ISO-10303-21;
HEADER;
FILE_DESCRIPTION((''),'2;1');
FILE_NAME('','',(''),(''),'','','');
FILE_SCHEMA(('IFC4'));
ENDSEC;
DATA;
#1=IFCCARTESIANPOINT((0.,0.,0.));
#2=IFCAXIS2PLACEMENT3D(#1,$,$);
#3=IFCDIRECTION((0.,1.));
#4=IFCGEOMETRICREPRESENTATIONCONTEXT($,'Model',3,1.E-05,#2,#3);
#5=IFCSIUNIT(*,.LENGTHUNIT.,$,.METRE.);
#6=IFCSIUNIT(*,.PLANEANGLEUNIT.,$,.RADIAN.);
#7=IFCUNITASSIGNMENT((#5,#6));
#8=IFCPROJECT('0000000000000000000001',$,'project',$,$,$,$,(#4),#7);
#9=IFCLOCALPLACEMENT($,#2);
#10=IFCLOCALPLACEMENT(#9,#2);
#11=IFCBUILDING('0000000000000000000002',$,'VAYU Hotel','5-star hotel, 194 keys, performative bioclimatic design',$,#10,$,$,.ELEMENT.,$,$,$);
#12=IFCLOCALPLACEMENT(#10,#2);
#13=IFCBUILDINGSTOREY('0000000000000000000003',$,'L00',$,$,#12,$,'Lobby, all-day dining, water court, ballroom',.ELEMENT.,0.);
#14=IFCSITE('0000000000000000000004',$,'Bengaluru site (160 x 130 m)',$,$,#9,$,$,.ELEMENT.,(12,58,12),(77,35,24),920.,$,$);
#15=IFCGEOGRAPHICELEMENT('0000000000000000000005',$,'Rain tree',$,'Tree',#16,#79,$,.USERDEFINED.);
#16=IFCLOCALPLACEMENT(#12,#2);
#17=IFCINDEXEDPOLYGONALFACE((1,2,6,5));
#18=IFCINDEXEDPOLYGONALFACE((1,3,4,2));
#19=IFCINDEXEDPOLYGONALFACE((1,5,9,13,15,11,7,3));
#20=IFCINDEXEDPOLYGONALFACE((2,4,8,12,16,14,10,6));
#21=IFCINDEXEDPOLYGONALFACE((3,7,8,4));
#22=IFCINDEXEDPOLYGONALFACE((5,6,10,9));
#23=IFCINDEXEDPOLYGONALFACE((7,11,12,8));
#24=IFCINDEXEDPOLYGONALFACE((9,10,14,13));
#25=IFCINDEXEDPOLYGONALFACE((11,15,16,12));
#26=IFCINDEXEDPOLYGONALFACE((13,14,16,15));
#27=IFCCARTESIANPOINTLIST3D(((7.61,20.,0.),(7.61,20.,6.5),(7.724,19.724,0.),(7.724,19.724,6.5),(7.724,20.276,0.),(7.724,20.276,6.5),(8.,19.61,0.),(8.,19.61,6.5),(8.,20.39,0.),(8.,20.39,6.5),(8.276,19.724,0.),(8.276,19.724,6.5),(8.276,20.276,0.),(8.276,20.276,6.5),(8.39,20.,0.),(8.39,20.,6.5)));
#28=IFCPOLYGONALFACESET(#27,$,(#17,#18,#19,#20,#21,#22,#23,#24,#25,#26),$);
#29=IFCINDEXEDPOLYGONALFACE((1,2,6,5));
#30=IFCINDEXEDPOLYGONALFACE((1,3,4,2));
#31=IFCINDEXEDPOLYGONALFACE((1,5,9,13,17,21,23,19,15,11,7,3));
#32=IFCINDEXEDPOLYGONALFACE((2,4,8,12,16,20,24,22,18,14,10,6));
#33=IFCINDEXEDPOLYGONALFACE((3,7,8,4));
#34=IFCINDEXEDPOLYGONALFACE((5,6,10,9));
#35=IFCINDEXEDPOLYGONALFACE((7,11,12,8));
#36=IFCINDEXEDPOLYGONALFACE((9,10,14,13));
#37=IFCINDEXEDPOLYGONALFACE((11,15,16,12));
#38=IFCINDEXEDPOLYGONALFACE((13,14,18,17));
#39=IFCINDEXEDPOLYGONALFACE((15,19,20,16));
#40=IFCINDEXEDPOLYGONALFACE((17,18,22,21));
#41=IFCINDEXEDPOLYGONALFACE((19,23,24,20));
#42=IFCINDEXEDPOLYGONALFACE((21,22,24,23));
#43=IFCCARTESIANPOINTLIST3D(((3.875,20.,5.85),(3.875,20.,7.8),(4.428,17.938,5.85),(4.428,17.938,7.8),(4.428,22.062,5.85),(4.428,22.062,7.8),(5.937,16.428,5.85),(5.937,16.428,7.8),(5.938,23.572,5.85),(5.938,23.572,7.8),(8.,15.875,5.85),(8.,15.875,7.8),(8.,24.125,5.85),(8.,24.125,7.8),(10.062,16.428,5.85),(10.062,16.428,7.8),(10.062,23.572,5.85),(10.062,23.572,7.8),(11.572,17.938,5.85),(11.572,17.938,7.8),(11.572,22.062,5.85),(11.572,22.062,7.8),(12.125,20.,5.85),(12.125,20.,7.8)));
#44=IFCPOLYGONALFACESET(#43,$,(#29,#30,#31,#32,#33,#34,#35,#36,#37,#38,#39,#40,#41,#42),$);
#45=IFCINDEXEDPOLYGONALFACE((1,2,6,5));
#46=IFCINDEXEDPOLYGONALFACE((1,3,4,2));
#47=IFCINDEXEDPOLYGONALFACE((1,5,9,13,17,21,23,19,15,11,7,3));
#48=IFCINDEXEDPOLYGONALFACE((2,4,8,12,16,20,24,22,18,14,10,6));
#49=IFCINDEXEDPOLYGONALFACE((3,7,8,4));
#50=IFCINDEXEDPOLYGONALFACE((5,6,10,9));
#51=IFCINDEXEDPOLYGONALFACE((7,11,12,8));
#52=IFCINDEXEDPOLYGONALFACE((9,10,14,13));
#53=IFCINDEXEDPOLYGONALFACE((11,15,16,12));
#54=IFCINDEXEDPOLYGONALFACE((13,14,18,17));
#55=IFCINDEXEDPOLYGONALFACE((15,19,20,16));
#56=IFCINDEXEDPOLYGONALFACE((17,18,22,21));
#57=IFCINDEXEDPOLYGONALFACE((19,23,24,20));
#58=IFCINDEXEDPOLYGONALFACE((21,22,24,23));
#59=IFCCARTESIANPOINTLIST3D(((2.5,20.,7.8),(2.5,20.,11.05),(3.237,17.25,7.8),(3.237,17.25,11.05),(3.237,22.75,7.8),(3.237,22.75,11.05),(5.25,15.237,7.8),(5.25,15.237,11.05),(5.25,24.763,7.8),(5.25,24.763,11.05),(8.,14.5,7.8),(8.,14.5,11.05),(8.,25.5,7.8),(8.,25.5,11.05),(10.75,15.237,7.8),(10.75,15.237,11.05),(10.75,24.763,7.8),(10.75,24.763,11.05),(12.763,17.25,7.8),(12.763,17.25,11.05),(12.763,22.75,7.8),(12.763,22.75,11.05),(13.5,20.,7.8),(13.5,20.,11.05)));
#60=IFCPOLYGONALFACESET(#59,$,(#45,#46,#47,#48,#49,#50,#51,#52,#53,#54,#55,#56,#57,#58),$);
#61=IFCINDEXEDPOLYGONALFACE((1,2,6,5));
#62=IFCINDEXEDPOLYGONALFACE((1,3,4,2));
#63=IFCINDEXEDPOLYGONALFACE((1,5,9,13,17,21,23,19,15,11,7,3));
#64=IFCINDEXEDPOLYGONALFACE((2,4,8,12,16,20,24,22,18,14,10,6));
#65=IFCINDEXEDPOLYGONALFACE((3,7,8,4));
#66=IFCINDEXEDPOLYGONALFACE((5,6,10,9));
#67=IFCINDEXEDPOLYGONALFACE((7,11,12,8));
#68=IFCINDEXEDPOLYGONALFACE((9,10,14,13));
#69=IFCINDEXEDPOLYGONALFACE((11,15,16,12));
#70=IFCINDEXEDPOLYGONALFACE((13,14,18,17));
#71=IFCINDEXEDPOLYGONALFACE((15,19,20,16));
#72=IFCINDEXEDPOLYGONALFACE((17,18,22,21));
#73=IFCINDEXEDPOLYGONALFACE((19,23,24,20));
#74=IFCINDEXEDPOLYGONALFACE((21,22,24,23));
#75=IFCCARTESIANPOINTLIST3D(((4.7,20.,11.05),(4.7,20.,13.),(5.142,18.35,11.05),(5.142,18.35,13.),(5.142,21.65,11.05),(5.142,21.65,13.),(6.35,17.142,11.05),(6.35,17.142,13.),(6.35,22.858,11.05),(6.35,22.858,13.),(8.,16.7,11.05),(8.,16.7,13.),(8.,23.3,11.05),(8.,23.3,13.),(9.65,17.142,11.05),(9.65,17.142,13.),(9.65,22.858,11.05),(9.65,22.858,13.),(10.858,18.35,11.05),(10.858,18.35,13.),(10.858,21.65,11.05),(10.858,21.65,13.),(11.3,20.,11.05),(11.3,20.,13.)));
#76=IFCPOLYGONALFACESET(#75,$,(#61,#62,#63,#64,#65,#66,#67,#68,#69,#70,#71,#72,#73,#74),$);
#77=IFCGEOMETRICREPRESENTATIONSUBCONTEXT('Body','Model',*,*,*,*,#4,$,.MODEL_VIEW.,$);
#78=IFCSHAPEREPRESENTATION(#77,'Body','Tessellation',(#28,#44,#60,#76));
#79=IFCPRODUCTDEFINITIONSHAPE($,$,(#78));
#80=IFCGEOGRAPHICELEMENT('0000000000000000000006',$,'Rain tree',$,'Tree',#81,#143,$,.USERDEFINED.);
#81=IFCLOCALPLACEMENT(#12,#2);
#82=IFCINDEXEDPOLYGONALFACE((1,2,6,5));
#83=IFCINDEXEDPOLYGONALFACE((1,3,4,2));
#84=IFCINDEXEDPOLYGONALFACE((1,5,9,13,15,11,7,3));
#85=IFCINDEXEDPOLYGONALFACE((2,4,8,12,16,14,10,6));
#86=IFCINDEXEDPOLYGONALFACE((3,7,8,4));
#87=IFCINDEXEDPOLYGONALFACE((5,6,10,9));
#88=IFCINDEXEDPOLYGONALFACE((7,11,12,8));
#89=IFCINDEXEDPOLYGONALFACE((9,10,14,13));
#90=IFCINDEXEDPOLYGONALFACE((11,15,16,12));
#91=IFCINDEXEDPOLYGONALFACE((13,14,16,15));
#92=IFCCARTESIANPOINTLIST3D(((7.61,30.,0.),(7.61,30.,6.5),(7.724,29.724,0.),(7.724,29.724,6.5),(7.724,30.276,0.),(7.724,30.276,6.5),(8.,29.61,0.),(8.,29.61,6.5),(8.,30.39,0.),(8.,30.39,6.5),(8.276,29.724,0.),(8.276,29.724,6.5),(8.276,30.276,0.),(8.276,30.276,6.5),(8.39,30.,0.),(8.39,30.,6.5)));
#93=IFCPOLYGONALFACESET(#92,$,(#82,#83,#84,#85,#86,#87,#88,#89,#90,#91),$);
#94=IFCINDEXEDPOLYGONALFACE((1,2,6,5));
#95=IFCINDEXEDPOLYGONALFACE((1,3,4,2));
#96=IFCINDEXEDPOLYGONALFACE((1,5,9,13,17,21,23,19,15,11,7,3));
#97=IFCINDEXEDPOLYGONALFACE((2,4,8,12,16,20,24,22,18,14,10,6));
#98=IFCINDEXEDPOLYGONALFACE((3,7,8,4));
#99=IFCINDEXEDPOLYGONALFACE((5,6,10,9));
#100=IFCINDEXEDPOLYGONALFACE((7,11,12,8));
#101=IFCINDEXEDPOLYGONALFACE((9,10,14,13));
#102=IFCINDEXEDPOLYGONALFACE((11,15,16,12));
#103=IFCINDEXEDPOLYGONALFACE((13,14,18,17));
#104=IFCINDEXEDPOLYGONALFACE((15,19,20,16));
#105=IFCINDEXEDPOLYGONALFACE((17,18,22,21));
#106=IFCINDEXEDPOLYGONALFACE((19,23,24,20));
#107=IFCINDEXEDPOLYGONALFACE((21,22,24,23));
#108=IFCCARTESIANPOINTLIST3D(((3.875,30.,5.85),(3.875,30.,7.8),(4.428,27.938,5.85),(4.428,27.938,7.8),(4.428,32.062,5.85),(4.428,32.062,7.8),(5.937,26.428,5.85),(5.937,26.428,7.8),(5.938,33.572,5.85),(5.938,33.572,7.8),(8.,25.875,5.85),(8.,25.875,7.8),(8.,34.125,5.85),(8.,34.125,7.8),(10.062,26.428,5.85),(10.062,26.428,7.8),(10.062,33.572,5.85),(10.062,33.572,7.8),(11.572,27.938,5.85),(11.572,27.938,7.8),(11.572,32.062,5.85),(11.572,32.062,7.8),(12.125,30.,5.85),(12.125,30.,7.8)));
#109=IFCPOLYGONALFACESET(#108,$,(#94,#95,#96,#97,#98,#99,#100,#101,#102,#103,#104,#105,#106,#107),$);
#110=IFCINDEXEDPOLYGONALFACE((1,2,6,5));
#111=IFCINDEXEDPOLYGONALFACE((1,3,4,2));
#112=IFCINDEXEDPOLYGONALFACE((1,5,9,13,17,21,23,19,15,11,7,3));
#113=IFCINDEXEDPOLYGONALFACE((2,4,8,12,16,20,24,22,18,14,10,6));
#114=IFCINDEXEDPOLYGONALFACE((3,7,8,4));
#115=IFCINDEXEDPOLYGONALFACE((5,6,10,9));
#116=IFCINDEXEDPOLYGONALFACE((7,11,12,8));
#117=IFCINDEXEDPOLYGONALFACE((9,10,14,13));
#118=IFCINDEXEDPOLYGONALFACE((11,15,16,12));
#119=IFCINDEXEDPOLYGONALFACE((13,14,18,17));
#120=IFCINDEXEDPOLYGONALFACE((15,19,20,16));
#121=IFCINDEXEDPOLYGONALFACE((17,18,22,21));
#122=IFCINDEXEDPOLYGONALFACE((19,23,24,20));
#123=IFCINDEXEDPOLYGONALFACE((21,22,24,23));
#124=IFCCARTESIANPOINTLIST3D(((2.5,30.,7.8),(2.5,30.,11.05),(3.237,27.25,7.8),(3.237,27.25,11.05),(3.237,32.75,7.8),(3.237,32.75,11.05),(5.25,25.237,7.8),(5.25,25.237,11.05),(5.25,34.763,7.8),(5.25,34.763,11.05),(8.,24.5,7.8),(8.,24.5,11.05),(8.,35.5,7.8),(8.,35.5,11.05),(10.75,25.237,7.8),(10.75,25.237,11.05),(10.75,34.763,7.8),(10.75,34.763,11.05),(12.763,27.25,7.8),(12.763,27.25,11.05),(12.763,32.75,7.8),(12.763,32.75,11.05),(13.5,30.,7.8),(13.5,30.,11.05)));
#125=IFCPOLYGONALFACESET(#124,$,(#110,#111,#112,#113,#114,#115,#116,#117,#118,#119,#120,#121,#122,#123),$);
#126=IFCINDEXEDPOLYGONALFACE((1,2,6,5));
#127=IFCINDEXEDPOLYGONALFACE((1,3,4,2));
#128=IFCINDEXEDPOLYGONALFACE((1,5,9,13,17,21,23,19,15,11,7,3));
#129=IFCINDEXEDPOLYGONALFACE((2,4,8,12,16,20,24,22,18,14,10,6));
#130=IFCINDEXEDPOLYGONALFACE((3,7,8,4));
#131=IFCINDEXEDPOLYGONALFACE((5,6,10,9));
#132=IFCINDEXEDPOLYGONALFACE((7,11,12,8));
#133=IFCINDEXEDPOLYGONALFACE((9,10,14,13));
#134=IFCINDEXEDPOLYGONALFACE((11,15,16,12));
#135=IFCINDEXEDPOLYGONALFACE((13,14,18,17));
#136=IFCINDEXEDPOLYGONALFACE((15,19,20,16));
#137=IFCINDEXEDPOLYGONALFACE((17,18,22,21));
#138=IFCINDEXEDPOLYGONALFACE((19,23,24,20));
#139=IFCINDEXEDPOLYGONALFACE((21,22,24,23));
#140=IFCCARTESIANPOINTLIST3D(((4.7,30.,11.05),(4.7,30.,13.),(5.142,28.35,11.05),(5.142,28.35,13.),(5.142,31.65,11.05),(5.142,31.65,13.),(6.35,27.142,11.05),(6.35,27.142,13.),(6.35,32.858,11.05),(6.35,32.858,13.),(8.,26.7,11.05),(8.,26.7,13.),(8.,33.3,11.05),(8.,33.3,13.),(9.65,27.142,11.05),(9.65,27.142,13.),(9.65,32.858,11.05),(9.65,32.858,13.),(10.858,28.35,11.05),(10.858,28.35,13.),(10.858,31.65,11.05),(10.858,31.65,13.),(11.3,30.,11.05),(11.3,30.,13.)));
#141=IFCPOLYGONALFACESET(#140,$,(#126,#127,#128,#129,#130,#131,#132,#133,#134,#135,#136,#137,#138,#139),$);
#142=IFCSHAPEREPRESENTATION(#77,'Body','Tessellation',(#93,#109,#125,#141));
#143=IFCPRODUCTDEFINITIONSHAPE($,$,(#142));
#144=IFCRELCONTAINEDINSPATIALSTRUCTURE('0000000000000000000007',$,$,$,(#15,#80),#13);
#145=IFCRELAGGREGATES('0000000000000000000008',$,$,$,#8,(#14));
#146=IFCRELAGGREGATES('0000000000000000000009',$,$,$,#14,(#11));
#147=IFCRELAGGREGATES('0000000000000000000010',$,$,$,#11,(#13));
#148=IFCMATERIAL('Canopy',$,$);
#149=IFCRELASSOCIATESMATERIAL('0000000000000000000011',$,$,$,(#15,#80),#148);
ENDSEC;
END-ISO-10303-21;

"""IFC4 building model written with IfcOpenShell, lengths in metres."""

from ifc_helpers import new_model, si_unit, direction, frame, origin, place, context, subcontext, project, spatial, polyline, outline, extrude, material, element, save


model = new_model("IFC4")

# Units and contexts
model_context = context("Model", 3, precision=1e-05, world=origin(), true_north=direction((0.0, 1.0)))
body_context = subcontext(model_context, "Body", "Model", "MODEL_VIEW")
ifc_project = project(units=[si_unit("LENGTHUNIT", "METRE"), si_unit("PLANEANGLEUNIT", "RADIAN")], contexts=[model_context])

# Site, building, storey
site_placement = place(None, origin())
site = spatial("IfcSite", under=ifc_project, at=site_placement, Name="Bengaluru site (160 x 130 m)", CompositionType="ELEMENT", RefLatitude=(12, 58, 12), RefLongitude=(77, 35, 24), RefElevation=920.0)
building_placement = place(site_placement, origin())
building = spatial("IfcBuilding", under=site, at=building_placement, Name="VAYU Hotel", Description="5-star hotel, 194 keys, performative bioclimatic design", CompositionType="ELEMENT")
storey_placement = place(building_placement, origin())
storey = spatial("IfcBuildingStorey", under=building, at=storey_placement, Name="L00", LongName="Lobby, all-day dining, water court, ballroom", CompositionType="ELEMENT", Elevation=0.0)

# Geographic elements
ifc_material_1 = material(Name="Canopy")
geographic_element_1_placement = place(storey_placement, origin())
element("IfcGeographicElement", 1, at=geographic_element_1_placement, inside=storey, material=ifc_material_1, Name="Rain tree", ObjectType="Tree", PredefinedType="USERDEFINED", context=body_context, shape_type="SweptSolid", body=[
    extrude(outline(polyline([(8.39, 20.0), (8.276, 20.276), (8.0, 20.39), (7.724, 20.276), (7.61, 20.0), (7.724, 19.724), (8.0, 19.61), (8.276, 19.724), (8.39, 20.0)])), origin(), (0.0, 0.0, 1.0), 6.5),
    extrude(outline(polyline([(12.125, 20.0), (11.572, 22.062), (10.062, 23.572), (8.0, 24.125), (5.938, 23.572), (4.428, 22.062), (3.875, 20.0), (4.428, 17.938), (5.937, 16.428), (8.0, 15.875), (10.062, 16.428), (11.572, 17.938), (12.125, 20.0)])), frame((0.0, 0.0, 5.85)), (0.0, 0.0, 1.0), 1.95),
    extrude(outline(polyline([(13.5, 20.0), (12.763, 22.75), (10.75, 24.763), (8.0, 25.5), (5.25, 24.763), (3.237, 22.75), (2.5, 20.0), (3.237, 17.25), (5.25, 15.237), (8.0, 14.5), (10.75, 15.237), (12.763, 17.25), (13.5, 20.0)])), frame((0.0, 0.0, 7.8)), (0.0, 0.0, 1.0), 3.25),
    extrude(outline(polyline([(11.3, 20.0), (10.858, 21.65), (9.65, 22.858), (8.0, 23.3), (6.35, 22.858), (5.142, 21.65), (4.7, 20.0), (5.142, 18.35), (6.35, 17.142), (8.0, 16.7), (9.65, 17.142), (10.858, 18.35), (11.3, 20.0)])), frame((0.0, 0.0, 11.05)), (0.0, 0.0, 1.0), 1.95),
])
geographic_element_2_placement = place(storey_placement, origin())
element("IfcGeographicElement", 2, at=geographic_element_2_placement, inside=storey, material=ifc_material_1, Name="Rain tree", ObjectType="Tree", PredefinedType="USERDEFINED", context=body_context, shape_type="SweptSolid", body=[
    extrude(outline(polyline([(8.39, 30.0), (8.276, 30.276), (8.0, 30.39), (7.724, 30.276), (7.61, 30.0), (7.724, 29.724), (8.0, 29.61), (8.276, 29.724), (8.39, 30.0)])), origin(), (0.0, 0.0, 1.0), 6.5),
    extrude(outline(polyline([(12.125, 30.0), (11.572, 32.062), (10.062, 33.572), (8.0, 34.125), (5.938, 33.572), (4.428, 32.062), (3.875, 30.0), (4.428, 27.938), (5.937, 26.428), (8.0, 25.875), (10.062, 26.428), (11.572, 27.938), (12.125, 30.0)])), frame((0.0, 0.0, 5.85)), (0.0, 0.0, 1.0), 1.95),
    extrude(outline(polyline([(13.5, 30.0), (12.763, 32.75), (10.75, 34.763), (8.0, 35.5), (5.25, 34.763), (3.237, 32.75), (2.5, 30.0), (3.237, 27.25), (5.25, 25.237), (8.0, 24.5), (10.75, 25.237), (12.763, 27.25), (13.5, 30.0)])), frame((0.0, 0.0, 7.8)), (0.0, 0.0, 1.0), 3.25),
    extrude(outline(polyline([(11.3, 30.0), (10.858, 31.65), (9.65, 32.858), (8.0, 33.3), (6.35, 32.858), (5.142, 31.65), (4.7, 30.0), (5.142, 28.35), (6.35, 27.142), (8.0, 26.7), (9.65, 27.142), (10.858, 28.35), (11.3, 30.0)])), frame((0.0, 0.0, 11.05)), (0.0, 0.0, 1.0), 1.95),
])

save(model, "model.ifc")
